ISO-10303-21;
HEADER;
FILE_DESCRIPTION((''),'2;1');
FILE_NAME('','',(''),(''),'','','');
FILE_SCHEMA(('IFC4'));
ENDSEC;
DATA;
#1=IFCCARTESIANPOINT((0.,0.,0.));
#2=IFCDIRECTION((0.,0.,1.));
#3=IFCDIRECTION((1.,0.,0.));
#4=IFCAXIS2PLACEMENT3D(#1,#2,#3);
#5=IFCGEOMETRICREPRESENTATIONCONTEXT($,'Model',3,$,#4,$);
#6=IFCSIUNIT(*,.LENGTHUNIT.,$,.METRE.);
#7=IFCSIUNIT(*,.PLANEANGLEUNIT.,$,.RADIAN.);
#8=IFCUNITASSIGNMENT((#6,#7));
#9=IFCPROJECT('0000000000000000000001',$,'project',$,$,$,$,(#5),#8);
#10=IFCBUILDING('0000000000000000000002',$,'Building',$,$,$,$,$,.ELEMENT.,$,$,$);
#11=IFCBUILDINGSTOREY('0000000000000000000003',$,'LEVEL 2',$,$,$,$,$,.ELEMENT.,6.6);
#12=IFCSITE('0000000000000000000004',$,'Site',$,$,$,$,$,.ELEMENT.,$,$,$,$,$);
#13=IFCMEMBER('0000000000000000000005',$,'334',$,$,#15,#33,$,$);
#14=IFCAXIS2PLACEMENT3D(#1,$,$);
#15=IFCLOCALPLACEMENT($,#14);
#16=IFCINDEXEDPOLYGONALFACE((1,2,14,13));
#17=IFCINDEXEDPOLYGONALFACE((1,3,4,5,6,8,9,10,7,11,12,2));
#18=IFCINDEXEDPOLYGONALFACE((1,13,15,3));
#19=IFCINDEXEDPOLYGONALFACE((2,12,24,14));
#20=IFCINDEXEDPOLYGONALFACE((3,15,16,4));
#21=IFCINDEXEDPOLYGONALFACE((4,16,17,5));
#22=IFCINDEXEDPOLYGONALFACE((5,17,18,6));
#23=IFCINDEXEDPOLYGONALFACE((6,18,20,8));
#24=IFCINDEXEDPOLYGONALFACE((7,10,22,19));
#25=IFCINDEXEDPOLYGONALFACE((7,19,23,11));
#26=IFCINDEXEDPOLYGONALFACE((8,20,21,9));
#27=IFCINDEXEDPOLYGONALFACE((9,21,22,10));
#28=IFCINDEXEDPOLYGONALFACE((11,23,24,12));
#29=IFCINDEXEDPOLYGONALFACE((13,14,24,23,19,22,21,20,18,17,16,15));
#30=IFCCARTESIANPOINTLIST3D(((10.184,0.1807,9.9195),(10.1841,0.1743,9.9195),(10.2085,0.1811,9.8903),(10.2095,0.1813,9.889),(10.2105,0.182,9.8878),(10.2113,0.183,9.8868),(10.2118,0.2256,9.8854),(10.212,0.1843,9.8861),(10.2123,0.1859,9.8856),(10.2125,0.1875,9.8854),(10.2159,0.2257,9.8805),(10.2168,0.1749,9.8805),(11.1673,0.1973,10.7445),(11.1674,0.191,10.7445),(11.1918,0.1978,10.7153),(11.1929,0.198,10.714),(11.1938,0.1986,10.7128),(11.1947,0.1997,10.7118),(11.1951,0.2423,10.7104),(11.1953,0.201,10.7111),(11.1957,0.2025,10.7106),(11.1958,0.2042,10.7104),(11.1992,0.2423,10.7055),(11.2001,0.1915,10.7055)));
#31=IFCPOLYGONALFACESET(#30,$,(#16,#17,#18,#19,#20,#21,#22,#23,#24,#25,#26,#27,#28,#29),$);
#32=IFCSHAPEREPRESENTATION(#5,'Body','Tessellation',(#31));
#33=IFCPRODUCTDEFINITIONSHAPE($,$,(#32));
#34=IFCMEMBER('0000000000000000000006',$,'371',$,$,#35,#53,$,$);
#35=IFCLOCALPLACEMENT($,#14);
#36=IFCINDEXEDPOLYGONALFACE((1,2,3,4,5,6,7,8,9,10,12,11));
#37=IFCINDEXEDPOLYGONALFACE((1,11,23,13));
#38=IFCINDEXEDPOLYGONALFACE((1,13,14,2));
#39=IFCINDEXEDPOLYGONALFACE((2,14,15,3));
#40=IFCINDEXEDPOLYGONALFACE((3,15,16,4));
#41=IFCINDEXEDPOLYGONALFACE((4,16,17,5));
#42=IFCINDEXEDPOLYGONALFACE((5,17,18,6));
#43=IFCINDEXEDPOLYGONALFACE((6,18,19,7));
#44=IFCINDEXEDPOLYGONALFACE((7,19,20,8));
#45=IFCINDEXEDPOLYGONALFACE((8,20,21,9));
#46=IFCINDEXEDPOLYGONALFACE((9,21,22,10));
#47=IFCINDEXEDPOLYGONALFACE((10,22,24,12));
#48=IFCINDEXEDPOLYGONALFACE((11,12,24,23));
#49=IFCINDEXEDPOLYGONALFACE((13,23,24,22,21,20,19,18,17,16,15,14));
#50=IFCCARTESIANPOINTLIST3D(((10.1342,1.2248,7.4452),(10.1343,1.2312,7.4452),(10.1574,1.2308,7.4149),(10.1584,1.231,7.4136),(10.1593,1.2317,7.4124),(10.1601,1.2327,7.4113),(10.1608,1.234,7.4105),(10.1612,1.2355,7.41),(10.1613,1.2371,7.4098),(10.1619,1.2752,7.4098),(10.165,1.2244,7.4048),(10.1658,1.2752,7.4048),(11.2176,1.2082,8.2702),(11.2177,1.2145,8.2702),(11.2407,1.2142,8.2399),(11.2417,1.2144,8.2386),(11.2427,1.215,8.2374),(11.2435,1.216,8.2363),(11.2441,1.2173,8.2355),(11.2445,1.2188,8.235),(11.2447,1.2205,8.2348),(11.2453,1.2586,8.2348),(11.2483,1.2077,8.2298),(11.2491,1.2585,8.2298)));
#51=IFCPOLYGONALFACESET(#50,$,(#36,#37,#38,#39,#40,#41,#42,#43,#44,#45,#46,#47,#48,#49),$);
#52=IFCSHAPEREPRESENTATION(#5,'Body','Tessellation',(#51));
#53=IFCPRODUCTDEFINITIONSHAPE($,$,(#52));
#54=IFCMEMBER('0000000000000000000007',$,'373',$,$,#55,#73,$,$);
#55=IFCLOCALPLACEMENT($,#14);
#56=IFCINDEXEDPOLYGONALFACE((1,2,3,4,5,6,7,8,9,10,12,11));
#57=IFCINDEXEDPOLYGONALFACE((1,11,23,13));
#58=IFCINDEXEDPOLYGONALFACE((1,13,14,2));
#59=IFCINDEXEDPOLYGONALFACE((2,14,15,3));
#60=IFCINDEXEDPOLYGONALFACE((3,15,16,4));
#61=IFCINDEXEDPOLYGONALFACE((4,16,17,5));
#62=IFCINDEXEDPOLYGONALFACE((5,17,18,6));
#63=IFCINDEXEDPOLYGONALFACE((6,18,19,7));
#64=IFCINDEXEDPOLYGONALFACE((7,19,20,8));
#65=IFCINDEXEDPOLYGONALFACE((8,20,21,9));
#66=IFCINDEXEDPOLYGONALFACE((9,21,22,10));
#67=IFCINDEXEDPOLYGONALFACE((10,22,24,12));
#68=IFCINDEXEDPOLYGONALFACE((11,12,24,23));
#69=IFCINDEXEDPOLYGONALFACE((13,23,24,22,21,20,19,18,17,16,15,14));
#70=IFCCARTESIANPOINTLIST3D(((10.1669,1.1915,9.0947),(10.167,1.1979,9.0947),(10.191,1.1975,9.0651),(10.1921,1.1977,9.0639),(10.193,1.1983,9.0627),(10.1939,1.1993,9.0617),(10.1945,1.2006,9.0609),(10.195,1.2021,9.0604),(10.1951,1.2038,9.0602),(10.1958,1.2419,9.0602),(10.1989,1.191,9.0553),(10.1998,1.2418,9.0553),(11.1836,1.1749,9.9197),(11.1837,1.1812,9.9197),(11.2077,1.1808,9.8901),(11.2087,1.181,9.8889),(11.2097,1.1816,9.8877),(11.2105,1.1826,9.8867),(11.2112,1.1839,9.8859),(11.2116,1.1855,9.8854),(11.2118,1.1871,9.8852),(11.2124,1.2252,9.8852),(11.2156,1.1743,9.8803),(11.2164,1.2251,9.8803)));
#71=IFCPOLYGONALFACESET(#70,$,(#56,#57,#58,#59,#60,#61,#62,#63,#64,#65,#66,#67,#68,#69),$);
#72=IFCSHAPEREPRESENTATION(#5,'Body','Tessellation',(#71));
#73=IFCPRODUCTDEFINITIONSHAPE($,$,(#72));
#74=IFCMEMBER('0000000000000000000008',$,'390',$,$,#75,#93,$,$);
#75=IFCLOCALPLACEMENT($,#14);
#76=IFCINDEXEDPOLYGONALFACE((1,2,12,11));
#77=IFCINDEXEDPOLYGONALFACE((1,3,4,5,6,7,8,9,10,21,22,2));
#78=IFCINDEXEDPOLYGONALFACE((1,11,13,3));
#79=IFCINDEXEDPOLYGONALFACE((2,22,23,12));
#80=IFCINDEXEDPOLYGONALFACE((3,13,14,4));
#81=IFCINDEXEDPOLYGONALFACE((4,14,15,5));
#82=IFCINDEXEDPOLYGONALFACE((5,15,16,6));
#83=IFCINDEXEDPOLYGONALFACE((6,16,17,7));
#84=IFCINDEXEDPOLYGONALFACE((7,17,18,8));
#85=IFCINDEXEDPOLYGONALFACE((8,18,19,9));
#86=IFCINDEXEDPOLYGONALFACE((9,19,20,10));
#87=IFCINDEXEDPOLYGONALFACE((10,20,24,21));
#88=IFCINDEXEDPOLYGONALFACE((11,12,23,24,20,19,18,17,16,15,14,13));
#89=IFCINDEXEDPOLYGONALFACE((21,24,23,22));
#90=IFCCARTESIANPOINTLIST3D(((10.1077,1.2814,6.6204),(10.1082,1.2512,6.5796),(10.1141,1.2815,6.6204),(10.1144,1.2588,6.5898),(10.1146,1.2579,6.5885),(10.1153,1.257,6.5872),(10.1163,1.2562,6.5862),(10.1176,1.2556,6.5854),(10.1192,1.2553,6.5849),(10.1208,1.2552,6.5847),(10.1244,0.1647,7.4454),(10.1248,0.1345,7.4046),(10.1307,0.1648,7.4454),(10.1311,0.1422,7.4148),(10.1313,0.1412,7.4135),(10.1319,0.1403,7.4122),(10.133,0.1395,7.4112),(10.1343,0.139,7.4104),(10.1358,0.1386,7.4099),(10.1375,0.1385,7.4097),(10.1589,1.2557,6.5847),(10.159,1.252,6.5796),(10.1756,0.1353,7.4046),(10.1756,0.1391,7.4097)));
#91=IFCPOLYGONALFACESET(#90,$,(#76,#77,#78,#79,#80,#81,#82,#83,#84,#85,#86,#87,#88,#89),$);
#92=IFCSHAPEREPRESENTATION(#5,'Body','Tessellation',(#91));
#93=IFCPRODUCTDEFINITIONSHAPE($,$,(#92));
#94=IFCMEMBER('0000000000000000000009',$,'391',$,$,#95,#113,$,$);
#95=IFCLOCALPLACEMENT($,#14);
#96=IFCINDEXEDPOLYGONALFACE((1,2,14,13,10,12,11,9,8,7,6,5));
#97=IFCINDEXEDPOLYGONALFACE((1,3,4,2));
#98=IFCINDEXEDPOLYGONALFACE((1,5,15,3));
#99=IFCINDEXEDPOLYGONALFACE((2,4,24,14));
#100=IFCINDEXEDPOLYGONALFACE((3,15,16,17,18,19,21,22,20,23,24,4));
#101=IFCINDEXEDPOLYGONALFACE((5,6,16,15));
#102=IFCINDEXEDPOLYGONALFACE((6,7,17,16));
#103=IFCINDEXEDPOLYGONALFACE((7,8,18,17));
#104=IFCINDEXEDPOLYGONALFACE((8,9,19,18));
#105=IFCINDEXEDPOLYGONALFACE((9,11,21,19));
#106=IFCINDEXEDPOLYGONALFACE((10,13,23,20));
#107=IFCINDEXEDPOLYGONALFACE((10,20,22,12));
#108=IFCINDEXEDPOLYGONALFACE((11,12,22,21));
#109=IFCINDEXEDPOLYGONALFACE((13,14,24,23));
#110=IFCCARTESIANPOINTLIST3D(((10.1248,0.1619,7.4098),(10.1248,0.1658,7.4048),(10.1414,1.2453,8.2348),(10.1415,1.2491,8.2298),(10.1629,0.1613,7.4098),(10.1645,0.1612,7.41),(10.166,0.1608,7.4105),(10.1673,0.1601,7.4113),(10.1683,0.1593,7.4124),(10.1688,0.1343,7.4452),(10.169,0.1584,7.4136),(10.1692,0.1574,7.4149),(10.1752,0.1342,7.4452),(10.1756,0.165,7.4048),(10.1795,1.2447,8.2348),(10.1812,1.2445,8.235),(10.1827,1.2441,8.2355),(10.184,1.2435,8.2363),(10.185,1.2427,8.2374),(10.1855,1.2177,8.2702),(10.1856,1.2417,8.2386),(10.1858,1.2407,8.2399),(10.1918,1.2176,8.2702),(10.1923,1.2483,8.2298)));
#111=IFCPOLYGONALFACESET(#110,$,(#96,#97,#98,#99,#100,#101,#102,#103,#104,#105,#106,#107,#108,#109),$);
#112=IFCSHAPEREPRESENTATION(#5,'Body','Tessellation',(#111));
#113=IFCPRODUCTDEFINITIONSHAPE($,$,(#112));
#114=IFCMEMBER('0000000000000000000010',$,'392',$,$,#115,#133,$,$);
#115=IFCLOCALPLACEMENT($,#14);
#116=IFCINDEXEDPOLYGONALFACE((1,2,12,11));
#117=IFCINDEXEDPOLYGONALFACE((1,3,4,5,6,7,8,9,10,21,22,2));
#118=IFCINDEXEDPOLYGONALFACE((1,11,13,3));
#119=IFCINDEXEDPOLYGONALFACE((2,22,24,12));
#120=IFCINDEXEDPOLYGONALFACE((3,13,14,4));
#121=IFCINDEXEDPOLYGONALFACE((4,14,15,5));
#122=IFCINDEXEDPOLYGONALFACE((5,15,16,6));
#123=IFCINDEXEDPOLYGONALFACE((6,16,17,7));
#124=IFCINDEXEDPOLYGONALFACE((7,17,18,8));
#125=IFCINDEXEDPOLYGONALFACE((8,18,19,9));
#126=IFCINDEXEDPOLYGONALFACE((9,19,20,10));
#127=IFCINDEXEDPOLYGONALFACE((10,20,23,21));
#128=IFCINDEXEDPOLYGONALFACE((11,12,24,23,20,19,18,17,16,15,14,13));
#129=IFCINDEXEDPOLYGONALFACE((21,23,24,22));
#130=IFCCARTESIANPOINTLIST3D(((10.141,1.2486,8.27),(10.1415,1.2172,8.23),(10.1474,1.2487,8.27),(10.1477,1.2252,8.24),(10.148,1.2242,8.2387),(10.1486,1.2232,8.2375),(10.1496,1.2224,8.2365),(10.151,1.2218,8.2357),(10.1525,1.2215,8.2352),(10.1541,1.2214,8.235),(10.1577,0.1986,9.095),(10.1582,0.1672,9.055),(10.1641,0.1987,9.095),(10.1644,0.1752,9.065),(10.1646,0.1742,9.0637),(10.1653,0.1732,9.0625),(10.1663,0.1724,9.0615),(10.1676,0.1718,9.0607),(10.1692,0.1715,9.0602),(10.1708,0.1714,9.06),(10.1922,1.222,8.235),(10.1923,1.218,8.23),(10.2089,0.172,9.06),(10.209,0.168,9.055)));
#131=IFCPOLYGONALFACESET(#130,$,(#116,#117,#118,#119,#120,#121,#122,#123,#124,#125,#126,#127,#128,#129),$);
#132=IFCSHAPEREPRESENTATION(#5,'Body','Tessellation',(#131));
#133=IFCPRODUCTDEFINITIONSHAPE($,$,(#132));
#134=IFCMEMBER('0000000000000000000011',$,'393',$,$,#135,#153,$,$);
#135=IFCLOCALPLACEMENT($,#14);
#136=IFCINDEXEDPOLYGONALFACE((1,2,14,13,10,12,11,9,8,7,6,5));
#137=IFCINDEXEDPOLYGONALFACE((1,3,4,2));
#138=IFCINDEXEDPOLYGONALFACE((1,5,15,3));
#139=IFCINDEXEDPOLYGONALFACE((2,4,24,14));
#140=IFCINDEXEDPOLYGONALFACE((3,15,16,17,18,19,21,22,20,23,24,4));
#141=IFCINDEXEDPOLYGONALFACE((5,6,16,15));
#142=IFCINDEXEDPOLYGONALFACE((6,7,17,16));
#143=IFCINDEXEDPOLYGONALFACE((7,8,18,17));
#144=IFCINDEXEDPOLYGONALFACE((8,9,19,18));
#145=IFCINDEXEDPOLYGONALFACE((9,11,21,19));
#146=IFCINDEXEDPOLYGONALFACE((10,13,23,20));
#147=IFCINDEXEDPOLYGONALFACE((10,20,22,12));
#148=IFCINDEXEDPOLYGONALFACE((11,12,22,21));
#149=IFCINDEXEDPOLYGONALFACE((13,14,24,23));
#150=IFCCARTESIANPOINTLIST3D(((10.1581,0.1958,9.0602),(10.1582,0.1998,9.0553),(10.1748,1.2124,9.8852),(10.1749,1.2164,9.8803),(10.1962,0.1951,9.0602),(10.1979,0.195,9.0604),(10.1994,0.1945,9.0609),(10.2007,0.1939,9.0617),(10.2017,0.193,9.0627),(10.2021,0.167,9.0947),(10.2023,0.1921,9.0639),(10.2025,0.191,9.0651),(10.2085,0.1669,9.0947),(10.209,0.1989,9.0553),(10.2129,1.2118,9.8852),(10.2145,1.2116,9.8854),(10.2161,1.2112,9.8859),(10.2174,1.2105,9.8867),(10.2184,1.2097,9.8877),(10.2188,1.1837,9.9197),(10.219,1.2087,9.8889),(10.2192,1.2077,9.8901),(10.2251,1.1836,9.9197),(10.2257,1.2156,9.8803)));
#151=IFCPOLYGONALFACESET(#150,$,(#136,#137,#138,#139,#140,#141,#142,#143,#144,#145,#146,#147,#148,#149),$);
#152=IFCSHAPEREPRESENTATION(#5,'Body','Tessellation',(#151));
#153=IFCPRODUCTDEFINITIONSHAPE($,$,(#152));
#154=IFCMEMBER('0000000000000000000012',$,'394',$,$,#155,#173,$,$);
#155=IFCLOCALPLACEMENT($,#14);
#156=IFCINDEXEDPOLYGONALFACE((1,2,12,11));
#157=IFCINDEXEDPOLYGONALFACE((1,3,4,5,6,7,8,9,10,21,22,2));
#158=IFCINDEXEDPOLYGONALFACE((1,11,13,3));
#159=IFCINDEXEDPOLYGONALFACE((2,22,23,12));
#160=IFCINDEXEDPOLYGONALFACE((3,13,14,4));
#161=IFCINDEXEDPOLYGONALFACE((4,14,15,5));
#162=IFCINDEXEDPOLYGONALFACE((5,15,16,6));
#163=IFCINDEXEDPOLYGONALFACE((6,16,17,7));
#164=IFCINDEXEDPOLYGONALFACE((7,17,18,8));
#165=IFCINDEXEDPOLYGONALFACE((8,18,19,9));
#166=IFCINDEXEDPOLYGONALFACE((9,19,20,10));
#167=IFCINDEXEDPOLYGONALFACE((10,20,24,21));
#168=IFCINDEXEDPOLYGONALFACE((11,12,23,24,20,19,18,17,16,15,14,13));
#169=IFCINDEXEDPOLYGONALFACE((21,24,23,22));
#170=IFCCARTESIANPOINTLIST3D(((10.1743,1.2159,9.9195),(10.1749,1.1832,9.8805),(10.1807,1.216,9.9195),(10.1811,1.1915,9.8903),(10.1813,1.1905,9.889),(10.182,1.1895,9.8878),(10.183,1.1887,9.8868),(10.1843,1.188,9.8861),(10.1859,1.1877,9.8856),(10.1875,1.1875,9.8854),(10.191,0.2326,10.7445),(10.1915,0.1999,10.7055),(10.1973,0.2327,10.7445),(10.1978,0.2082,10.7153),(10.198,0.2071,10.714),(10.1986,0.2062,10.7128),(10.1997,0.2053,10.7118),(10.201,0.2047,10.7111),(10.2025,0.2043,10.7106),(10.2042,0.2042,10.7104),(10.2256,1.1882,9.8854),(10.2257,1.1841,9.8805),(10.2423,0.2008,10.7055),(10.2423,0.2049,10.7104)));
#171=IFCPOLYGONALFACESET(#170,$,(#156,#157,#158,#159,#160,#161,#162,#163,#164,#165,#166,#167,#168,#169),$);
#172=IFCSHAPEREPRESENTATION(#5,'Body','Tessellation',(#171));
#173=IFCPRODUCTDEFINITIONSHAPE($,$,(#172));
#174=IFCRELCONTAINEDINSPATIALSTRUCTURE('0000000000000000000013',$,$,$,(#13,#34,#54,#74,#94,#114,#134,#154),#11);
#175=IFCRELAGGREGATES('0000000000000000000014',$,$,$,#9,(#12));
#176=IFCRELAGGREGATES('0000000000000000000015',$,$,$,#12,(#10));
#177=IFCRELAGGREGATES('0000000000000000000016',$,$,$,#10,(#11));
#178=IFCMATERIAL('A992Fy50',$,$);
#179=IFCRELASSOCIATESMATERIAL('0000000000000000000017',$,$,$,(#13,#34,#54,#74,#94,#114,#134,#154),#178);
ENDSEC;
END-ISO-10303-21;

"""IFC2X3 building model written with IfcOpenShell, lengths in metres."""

from ifc_helpers import new_model, si_unit, frame, origin_with_axes, origin_2d_with_axis, place, context, project, spatial, l_section, extrude, material, element, save


model = new_model("IFC2X3")

# Units and contexts
model_context = context("Model", 3, world=origin_with_axes())
ifc_project = project(units=[si_unit("LENGTHUNIT", "METRE"), si_unit("PLANEANGLEUNIT", "RADIAN")], contexts=[model_context])

# Site, building, storey
site = spatial("IfcSite", under=ifc_project, Name="Site", CompositionType="ELEMENT")
building = spatial("IfcBuilding", under=site, Name="Building", CompositionType="ELEMENT")
storey = spatial("IfcBuildingStorey", under=building, Name="LEVEL 2", CompositionType="ELEMENT", Elevation=6.6)

# Shared definitions
ifc_material = material(Name="A992Fy50")

# Members
member_1_placement = place(None, frame((10.2, 0.2, 9.9), z_axis=(0.766024, 0.012983, 0.642681), x_axis=(-0.016947, 0.999856, 0.0)))
element("IfcMember", 1, at=member_1_placement, inside=storey, material=ifc_material, Name="334", context=model_context, shape_type="SweptSolid", body=[
    extrude(l_section(Depth=0.0508, Width=0.0508, Thickness=0.0063, FilletRadius=0.0063, at=origin_2d_with_axis()), origin_with_axes(), (0.0, 0.0, 1.0), 1.2837),
])
member_2_placement = place(None, frame((10.15, 1.25, 7.425), z_axis=(0.795513, -0.012239, 0.605813), x_axis=(0.015383, 0.999882, 0.0)))
element("IfcMember", 2, at=member_2_placement, inside=storey, material=ifc_material, Name="371", context=model_context, shape_type="SweptSolid", body=[
    extrude(l_section(Depth=0.0508, Width=0.0508, Thickness=0.0063, FilletRadius=0.0063, at=origin_2d_with_axis()), origin_with_axes(), (0.0, 0.0, 1.0), 1.3618),
])
member_3_placement = place(None, frame((10.1833, 1.2167, 9.075), z_axis=(0.77644, -0.012729, 0.630062), x_axis=(0.016391, 0.999866, 0.0)))
element("IfcMember", 3, at=member_3_placement, inside=storey, material=ifc_material, Name="373", context=model_context, shape_type="SweptSolid", body=[
    extrude(l_section(Depth=0.0508, Width=0.0508, Thickness=0.0063, FilletRadius=0.0063, at=origin_2d_with_axis()), origin_with_axes(), (0.0, 0.0, 1.0), 1.3094),
])
member_4_placement = place(None, frame((10.1333, 1.2667, 6.6), z_axis=(0.012004, -0.804243, 0.594179), x_axis=(0.999889, 0.014924, 0.0)))
element("IfcMember", 4, at=member_4_placement, inside=storey, material=ifc_material, Name="390", context=model_context, shape_type="SweptSolid", body=[
    extrude(l_section(Depth=0.0508, Width=0.0508, Thickness=0.0063, FilletRadius=0.0063, at=origin_2d_with_axis()), origin_with_axes(), (0.0, 0.0, 1.0), 1.3885),
])
member_5_placement = place(None, frame((10.15, 0.15, 7.425), z_axis=(0.012239, 0.795513, 0.605813), x_axis=(-0.999882, 0.015383, 0.0)))
element("IfcMember", 5, at=member_5_placement, inside=storey, material=ifc_material, Name="391", context=model_context, shape_type="SweptSolid", body=[
    extrude(l_section(Depth=0.0508, Width=0.0508, Thickness=0.0063, FilletRadius=0.0063, at=origin_2d_with_axis()), origin_with_axes(), (0.0, 0.0, 1.0), 1.3618),
])
member_6_placement = place(None, frame((10.1667, 1.2333, 8.25), z_axis=(0.01248, -0.786257, 0.617773), x_axis=(0.999889, 0.014924, 0.0)))
element("IfcMember", 6, at=member_6_placement, inside=storey, material=ifc_material, Name="392", context=model_context, shape_type="SweptSolid", body=[
    extrude(l_section(Depth=0.0508, Width=0.0508, Thickness=0.0063, FilletRadius=0.0063, at=origin_2d_with_axis()), origin_with_axes(), (0.0, 0.0, 1.0), 1.3354),
])
member_7_placement = place(None, frame((10.1833, 0.1833, 9.075), z_axis=(0.012729, 0.77644, 0.630062), x_axis=(-0.999866, 0.016391, 0.0)))
element("IfcMember", 7, at=member_7_placement, inside=storey, material=ifc_material, Name="393", context=model_context, shape_type="SweptSolid", body=[
    extrude(l_section(Depth=0.0508, Width=0.0508, Thickness=0.0063, FilletRadius=0.0063, at=origin_2d_with_axis()), origin_with_axes(), (0.0, 0.0, 1.0), 1.3094),
])
member_8_placement = place(None, frame((10.2, 1.2, 9.9), z_axis=(0.012983, -0.766024, 0.642681), x_axis=(0.999856, 0.016947, 0.0)))
element("IfcMember", 8, at=member_8_placement, inside=storey, material=ifc_material, Name="394", context=model_context, shape_type="SweptSolid", body=[
    extrude(l_section(Depth=0.0508, Width=0.0508, Thickness=0.0063, FilletRadius=0.0063, at=origin_2d_with_axis()), origin_with_axes(), (0.0, 0.0, 1.0), 1.2837),
])

save(model, "model.ifc")
